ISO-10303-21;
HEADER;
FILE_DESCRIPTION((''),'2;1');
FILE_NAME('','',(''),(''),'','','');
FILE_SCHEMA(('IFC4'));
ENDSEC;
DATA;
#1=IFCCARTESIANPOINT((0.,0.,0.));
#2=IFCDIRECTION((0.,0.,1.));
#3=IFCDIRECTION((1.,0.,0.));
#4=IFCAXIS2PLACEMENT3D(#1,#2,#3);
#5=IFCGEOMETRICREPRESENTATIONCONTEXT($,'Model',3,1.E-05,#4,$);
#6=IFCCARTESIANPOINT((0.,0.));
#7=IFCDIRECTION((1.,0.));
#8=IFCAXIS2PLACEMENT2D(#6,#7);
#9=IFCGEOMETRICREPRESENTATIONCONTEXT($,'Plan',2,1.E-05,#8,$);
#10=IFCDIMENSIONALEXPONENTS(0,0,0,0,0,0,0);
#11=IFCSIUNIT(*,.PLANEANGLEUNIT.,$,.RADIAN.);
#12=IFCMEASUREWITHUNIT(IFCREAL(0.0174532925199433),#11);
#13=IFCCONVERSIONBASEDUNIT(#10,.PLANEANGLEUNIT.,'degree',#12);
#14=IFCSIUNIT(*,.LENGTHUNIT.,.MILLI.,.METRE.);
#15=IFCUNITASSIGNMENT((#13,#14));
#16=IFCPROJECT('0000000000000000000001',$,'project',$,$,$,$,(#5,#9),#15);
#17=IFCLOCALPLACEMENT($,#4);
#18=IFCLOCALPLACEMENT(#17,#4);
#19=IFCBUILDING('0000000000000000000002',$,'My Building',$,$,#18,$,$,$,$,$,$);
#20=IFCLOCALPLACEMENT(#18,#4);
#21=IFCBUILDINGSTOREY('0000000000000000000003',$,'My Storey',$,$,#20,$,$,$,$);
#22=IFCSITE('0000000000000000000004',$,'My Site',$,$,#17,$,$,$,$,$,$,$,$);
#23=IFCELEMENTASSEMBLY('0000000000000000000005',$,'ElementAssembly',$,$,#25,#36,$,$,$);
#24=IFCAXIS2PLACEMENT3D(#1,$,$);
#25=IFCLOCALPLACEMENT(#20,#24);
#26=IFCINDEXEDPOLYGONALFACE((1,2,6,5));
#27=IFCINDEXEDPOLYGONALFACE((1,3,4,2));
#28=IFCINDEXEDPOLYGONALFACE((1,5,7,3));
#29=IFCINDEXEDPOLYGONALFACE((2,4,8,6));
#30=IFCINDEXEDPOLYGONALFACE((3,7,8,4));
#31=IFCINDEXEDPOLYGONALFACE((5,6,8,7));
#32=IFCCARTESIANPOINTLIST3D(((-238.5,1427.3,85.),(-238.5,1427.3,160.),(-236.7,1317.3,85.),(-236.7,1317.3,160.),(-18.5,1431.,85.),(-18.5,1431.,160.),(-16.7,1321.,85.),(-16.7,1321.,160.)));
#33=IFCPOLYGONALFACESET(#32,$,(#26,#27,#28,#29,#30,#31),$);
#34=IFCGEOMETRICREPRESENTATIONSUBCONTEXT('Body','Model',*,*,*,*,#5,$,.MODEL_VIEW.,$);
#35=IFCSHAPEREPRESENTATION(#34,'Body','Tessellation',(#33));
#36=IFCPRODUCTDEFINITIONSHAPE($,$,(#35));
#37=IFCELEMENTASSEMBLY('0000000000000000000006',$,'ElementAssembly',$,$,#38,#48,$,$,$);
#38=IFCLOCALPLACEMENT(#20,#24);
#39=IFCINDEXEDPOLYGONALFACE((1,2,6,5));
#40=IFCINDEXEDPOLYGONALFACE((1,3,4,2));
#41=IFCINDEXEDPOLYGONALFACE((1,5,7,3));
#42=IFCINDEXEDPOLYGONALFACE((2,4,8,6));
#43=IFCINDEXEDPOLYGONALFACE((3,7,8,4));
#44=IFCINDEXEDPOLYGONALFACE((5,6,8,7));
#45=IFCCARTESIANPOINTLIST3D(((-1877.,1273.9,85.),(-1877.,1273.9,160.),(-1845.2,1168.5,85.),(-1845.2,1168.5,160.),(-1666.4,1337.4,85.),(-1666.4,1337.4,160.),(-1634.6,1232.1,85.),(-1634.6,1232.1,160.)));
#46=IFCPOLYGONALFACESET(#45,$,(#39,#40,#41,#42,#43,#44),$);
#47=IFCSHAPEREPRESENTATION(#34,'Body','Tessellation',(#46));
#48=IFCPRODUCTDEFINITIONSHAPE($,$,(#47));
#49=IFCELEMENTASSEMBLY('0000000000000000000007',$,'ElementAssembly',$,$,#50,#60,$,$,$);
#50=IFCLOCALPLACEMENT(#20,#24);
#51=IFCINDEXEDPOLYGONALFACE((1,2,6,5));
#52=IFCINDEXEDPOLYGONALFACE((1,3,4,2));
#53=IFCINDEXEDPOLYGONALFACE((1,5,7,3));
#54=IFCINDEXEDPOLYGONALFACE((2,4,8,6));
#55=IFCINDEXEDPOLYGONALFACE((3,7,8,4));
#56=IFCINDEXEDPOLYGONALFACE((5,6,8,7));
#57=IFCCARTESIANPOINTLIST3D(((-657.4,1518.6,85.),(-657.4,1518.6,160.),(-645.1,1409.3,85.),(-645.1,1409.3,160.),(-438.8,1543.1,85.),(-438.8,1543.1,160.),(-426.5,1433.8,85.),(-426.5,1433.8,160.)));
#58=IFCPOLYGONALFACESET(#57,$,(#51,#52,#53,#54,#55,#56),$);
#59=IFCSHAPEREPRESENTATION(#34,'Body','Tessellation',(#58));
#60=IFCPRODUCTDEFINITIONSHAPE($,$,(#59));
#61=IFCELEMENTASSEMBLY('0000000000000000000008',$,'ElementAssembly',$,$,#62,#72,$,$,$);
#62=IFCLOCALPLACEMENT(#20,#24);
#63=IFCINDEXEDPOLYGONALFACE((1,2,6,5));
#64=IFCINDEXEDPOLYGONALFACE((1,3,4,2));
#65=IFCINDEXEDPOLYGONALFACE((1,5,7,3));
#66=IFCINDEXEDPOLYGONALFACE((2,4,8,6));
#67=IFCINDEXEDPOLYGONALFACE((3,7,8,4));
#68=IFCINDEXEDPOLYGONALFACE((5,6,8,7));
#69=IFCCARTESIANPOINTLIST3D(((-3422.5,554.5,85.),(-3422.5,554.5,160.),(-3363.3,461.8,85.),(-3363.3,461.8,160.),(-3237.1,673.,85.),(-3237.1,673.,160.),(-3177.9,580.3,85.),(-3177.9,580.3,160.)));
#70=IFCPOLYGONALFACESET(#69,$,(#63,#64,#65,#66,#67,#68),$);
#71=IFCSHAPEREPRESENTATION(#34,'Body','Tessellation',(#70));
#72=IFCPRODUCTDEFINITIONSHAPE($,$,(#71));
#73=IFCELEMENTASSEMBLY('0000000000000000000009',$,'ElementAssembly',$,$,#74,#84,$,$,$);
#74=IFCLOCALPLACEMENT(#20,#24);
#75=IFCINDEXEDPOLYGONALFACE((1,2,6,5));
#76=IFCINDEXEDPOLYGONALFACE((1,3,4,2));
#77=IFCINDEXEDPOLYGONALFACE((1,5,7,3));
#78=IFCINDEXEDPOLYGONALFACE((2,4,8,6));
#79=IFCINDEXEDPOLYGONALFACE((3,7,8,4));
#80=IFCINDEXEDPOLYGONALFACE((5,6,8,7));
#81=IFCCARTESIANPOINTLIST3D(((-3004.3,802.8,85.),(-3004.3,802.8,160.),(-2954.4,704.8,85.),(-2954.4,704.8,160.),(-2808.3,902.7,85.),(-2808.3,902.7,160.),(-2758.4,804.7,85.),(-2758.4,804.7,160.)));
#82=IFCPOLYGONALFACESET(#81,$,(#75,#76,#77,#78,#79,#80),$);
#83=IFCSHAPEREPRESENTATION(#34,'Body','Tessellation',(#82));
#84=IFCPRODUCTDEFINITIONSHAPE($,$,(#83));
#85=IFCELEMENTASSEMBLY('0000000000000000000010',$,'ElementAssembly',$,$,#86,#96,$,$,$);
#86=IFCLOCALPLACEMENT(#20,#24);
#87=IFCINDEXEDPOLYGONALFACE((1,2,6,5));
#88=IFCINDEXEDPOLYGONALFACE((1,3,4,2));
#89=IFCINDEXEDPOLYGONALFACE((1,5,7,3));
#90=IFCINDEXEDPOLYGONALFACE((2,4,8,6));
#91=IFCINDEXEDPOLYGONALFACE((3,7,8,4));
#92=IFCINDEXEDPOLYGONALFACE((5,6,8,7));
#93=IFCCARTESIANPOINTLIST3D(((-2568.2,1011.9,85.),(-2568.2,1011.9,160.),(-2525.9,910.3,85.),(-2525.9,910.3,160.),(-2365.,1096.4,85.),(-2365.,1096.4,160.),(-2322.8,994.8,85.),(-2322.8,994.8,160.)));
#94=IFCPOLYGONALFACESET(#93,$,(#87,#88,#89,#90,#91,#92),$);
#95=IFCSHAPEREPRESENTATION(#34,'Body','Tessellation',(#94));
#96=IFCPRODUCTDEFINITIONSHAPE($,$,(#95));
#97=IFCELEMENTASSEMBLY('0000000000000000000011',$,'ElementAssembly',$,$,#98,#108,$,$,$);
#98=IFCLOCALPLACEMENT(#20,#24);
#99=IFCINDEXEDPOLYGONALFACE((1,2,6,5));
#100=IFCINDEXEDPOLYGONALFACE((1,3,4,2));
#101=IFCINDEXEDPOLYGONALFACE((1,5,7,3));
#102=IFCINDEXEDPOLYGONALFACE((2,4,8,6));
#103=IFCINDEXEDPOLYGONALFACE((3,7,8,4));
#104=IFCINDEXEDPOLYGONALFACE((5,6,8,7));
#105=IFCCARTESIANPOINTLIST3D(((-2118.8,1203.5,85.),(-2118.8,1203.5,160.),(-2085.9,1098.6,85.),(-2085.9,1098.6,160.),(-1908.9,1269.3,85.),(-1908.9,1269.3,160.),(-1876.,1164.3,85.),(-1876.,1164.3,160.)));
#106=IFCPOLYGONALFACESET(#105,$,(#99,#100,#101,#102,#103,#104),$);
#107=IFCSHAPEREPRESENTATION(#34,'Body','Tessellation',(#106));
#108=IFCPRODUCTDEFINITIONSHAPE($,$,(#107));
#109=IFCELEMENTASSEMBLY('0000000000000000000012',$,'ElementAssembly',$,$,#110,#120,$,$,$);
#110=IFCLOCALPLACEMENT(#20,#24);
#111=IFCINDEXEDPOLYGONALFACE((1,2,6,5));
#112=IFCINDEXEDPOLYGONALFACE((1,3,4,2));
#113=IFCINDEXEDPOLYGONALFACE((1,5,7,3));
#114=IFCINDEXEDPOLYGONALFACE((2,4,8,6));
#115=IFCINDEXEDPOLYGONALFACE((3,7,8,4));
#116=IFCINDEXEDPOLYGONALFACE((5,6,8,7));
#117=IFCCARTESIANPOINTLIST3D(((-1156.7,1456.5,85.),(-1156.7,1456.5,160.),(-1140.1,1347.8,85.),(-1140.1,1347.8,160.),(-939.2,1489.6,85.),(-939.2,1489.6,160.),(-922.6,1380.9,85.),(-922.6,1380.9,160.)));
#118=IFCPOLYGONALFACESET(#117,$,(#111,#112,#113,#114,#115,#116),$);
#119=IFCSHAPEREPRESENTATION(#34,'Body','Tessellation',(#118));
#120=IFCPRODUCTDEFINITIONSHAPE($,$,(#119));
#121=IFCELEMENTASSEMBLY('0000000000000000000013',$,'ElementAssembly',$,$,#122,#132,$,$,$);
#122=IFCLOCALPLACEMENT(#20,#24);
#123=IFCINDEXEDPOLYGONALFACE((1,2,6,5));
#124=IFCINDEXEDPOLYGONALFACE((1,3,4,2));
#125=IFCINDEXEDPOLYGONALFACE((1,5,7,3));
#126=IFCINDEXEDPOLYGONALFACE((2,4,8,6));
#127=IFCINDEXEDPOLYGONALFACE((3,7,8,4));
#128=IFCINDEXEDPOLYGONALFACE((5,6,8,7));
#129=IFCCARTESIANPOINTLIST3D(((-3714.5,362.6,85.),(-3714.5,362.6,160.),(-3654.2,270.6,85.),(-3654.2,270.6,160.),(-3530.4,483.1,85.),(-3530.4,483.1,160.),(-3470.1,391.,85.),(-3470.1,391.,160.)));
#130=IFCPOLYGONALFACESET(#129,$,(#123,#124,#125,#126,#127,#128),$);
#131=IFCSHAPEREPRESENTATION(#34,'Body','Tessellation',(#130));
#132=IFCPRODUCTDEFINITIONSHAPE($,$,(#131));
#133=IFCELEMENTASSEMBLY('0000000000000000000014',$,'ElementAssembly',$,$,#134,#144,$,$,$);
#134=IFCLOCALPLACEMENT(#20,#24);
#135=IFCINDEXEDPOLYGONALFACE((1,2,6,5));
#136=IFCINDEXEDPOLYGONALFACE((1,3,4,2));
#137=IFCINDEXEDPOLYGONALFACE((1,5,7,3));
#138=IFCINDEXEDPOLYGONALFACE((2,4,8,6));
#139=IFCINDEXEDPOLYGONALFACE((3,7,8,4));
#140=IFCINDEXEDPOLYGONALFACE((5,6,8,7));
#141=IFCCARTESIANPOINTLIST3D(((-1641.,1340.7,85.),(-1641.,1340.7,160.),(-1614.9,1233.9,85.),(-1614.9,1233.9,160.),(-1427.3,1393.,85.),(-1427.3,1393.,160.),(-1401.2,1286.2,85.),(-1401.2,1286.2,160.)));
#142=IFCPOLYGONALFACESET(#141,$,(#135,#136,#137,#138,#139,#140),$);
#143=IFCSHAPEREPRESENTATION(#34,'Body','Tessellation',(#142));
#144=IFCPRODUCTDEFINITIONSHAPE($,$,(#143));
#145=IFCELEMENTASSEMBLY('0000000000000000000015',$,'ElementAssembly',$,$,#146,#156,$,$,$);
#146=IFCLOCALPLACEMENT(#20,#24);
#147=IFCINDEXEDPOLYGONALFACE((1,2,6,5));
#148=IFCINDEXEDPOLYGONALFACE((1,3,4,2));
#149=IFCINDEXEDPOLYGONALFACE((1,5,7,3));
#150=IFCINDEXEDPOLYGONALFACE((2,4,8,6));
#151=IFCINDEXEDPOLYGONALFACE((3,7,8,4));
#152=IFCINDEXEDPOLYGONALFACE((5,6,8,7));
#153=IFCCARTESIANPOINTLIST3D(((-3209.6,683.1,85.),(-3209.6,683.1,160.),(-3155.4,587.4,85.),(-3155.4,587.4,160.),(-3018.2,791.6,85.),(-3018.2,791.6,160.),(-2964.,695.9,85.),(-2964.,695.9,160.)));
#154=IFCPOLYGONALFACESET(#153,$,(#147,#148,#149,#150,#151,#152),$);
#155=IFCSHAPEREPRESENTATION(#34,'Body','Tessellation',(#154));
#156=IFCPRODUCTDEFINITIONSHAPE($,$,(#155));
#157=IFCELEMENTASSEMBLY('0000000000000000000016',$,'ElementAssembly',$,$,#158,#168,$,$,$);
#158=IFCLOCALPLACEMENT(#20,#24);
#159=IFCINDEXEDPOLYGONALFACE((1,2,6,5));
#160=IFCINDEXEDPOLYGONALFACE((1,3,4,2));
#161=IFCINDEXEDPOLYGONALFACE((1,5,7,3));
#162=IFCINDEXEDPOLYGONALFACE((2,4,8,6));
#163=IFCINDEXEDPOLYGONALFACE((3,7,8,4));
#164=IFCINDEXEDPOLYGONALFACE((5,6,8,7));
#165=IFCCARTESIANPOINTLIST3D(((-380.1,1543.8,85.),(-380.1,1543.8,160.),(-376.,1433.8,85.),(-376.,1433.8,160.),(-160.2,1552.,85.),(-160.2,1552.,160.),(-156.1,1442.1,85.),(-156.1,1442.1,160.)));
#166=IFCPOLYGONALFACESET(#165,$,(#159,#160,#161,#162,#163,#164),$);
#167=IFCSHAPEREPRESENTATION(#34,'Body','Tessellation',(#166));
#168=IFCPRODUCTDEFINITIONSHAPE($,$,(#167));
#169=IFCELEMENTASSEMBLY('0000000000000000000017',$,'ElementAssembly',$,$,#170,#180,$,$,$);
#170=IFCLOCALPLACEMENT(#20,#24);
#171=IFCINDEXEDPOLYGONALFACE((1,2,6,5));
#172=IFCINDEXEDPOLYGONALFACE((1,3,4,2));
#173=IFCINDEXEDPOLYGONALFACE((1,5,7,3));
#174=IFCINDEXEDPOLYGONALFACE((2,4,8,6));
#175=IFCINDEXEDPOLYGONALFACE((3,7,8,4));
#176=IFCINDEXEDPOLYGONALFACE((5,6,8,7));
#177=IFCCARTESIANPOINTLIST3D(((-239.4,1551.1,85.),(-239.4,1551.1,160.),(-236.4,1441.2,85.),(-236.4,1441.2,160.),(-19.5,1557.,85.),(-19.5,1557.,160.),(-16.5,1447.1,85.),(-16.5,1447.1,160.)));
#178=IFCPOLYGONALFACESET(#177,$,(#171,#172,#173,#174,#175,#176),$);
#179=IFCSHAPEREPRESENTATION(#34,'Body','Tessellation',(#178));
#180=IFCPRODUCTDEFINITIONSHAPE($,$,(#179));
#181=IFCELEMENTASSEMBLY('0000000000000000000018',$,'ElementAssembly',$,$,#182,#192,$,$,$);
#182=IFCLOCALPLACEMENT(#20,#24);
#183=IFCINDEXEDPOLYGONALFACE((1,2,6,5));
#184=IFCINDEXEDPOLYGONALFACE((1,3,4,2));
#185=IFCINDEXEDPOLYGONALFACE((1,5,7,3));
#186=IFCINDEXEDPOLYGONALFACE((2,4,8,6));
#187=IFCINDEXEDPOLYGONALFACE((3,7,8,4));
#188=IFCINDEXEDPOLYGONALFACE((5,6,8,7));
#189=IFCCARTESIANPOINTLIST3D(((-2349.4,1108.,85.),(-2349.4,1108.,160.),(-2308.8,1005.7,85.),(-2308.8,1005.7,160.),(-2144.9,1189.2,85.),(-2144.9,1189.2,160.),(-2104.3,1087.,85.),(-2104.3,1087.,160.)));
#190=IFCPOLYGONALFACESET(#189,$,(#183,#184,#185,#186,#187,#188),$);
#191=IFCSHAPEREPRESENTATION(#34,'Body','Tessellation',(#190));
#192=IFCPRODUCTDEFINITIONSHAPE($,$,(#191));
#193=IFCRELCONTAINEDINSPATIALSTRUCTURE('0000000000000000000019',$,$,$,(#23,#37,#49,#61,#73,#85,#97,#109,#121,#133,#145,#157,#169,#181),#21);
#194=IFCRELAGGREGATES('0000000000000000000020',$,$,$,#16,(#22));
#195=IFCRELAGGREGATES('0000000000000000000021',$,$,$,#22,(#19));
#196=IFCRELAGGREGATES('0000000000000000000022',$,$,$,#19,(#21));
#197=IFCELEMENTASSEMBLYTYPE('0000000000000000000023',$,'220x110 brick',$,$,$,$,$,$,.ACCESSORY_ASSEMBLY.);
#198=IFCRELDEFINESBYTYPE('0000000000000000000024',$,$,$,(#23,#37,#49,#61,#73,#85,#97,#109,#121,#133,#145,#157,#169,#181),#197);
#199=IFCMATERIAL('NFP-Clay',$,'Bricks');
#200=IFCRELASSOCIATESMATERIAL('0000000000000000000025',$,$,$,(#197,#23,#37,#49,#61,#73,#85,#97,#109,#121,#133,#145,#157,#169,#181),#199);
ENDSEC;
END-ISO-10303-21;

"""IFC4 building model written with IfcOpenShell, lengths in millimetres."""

from ifc_helpers import new_model, entity, si_unit, converted_unit, frame, origin_with_axes, origin_2d_with_axis, place, context, subcontext, project, spatial, rectangle, extrude, material, material_profile, profile_set, profile_usage, type_object, element, save


model = new_model("IFC4")

# Units and contexts
model_context = context("Model", 3, precision=1e-05, world=origin_with_axes())
plan_context = context("Plan", 2, precision=1e-05, world=origin_2d_with_axis())
body_context = subcontext(model_context, "Body", "Model", "MODEL_VIEW")
ifc_project = project(units=[converted_unit("PLANEANGLEUNIT", "degree", entity("IfcReal", 0.0174532925199433), si_unit("PLANEANGLEUNIT", "RADIAN"), dimensions=[0, 0, 0, 0, 0, 0, 0]), si_unit("LENGTHUNIT", "METRE", prefix="MILLI")], contexts=[model_context, plan_context])

# Site, building, storey
site_placement = place(None, origin_with_axes())
site = spatial("IfcSite", under=ifc_project, at=site_placement, Name="My Site")
building_placement = place(site_placement, origin_with_axes())
building = spatial("IfcBuilding", under=site, at=building_placement, Name="My Building")
storey_placement = place(building_placement, origin_with_axes())
storey = spatial("IfcBuildingStorey", under=building, at=storey_placement, Name="My Storey")

# Element assemblies
ifc_material = material(Name="NFP-Clay", Category="Bricks")
ifc_material_profile = material_profile(ifc_material, rectangle(XDim=220.0, YDim=110.0))
ifc_profile_set = profile_set([ifc_material_profile])
element_assembly_type = type_object("IfcElementAssemblyType", Name="220x110 brick", PredefinedType="ACCESSORY_ASSEMBLY", material=ifc_profile_set)
ifc_profile_usage_1 = profile_usage(ifc_profile_set, cardinal=5)
assembly_1_placement = place(storey_placement, frame((-127.6, 1374.2, 85.0), z_axis=(0.0, 0.0, 1.0), x_axis=(0.999857, 0.016917, 0.0)))
element("IfcElementAssembly", 1, at=assembly_1_placement, inside=storey, type_object=element_assembly_type, material=ifc_profile_usage_1, Name="ElementAssembly", context=body_context, shape_type="SweptSolid", body=[
    extrude(rectangle(XDim=220.0, YDim=110.0), origin_with_axes(), (0.0, 0.0, 1.0), 75.0),
])
ifc_profile_usage_2 = profile_usage(ifc_profile_set, cardinal=5)
assembly_2_placement = place(storey_placement, frame((-1755.8, 1253.0, 85.0), z_axis=(0.0, 0.0, 1.0), x_axis=(0.957384, 0.288817, 0.0)))
element("IfcElementAssembly", 2, at=assembly_2_placement, inside=storey, type_object=element_assembly_type, material=ifc_profile_usage_2, Name="ElementAssembly", context=body_context, shape_type="SweptSolid", body=[
    extrude(rectangle(XDim=220.0, YDim=110.0), origin_with_axes(), (0.0, 0.0, 1.0), 75.0),
])
ifc_profile_usage_3 = profile_usage(ifc_profile_set, cardinal=5)
assembly_3_placement = place(storey_placement, frame((-542.0, 1476.2, 85.0), z_axis=(0.0, 0.0, 1.0), x_axis=(0.993747, 0.111655, 0.0)))
element("IfcElementAssembly", 3, at=assembly_3_placement, inside=storey, type_object=element_assembly_type, material=ifc_profile_usage_3, Name="ElementAssembly", context=body_context, shape_type="SweptSolid", body=[
    extrude(rectangle(XDim=220.0, YDim=110.0), origin_with_axes(), (0.0, 0.0, 1.0), 75.0),
])
ifc_profile_usage_4 = profile_usage(ifc_profile_set, cardinal=5)
assembly_4_placement = place(storey_placement, frame((-3300.2, 567.4, 85.0), z_axis=(0.0, 0.0, 1.0), x_axis=(0.842597, 0.538544, 0.0)))
element("IfcElementAssembly", 4, at=assembly_4_placement, inside=storey, type_object=element_assembly_type, material=ifc_profile_usage_4, Name="ElementAssembly", context=body_context, shape_type="SweptSolid", body=[
    extrude(rectangle(XDim=220.0, YDim=110.0), origin_with_axes(), (0.0, 0.0, 1.0), 75.0),
])
ifc_profile_usage_5 = profile_usage(ifc_profile_set, cardinal=5)
assembly_5_placement = place(storey_placement, frame((-2881.3, 803.8, 85.0), z_axis=(0.0, 0.0, 1.0), x_axis=(0.890943, 0.454115, 0.0)))
element("IfcElementAssembly", 5, at=assembly_5_placement, inside=storey, type_object=element_assembly_type, material=ifc_profile_usage_5, Name="ElementAssembly", context=body_context, shape_type="SweptSolid", body=[
    extrude(rectangle(XDim=220.0, YDim=110.0), origin_with_axes(), (0.0, 0.0, 1.0), 75.0),
])
ifc_profile_usage_6 = profile_usage(ifc_profile_set, cardinal=5)
assembly_6_placement = place(storey_placement, frame((-2445.5, 1003.3, 85.0), z_axis=(0.0, 0.0, 1.0), x_axis=(0.923349, 0.383961, 0.0)))
element("IfcElementAssembly", 6, at=assembly_6_placement, inside=storey, type_object=element_assembly_type, material=ifc_profile_usage_6, Name="ElementAssembly", context=body_context, shape_type="SweptSolid", body=[
    extrude(rectangle(XDim=220.0, YDim=110.0), origin_with_axes(), (0.0, 0.0, 1.0), 75.0),
])
ifc_profile_usage_7 = profile_usage(ifc_profile_set, cardinal=5)
assembly_7_placement = place(storey_placement, frame((-1997.4, 1183.9, 85.0), z_axis=(0.0, 0.0, 1.0), x_axis=(0.954249, 0.299013, 0.0)))
element("IfcElementAssembly", 7, at=assembly_7_placement, inside=storey, type_object=element_assembly_type, material=ifc_profile_usage_7, Name="ElementAssembly", context=body_context, shape_type="SweptSolid", body=[
    extrude(rectangle(XDim=220.0, YDim=110.0), origin_with_axes(), (0.0, 0.0, 1.0), 75.0),
])
ifc_profile_usage_8 = profile_usage(ifc_profile_set, cardinal=5)
assembly_8_placement = place(storey_placement, frame((-1039.7, 1418.7, 85.0), z_axis=(0.0, 0.0, 1.0), x_axis=(0.98862, 0.150436, 0.0)))
element("IfcElementAssembly", 8, at=assembly_8_placement, inside=storey, type_object=element_assembly_type, material=ifc_profile_usage_8, Name="ElementAssembly", context=body_context, shape_type="SweptSolid", body=[
    extrude(rectangle(XDim=220.0, YDim=110.0), origin_with_axes(), (0.0, 0.0, 1.0), 75.0),
])
ifc_profile_usage_9 = profile_usage(ifc_profile_set, cardinal=5)
assembly_9_placement = place(storey_placement, frame((-3592.3, 376.8, 85.0), z_axis=(0.0, 0.0, 1.0), x_axis=(0.836805, 0.547502, 0.0)))
element("IfcElementAssembly", 9, at=assembly_9_placement, inside=storey, type_object=element_assembly_type, material=ifc_profile_usage_9, Name="ElementAssembly", context=body_context, shape_type="SweptSolid", body=[
    extrude(rectangle(XDim=220.0, YDim=110.0), origin_with_axes(), (0.0, 0.0, 1.0), 75.0),
])
ifc_profile_usage_10 = profile_usage(ifc_profile_set, cardinal=5)
assembly_10_placement = place(storey_placement, frame((-1521.1, 1313.4, 85.0), z_axis=(0.0, 0.0, 1.0), x_axis=(0.971317, 0.237789, 0.0)))
element("IfcElementAssembly", 10, at=assembly_10_placement, inside=storey, type_object=element_assembly_type, material=ifc_profile_usage_10, Name="ElementAssembly", context=body_context, shape_type="SweptSolid", body=[
    extrude(rectangle(XDim=220.0, YDim=110.0), origin_with_axes(), (0.0, 0.0, 1.0), 75.0),
])
ifc_profile_usage_11 = profile_usage(ifc_profile_set, cardinal=5)
assembly_11_placement = place(storey_placement, frame((-3086.8, 689.5, 85.0), z_axis=(0.0, 0.0, 1.0), x_axis=(0.869896, 0.493236, 0.0)))
element("IfcElementAssembly", 11, at=assembly_11_placement, inside=storey, type_object=element_assembly_type, material=ifc_profile_usage_11, Name="ElementAssembly", context=body_context, shape_type="SweptSolid", body=[
    extrude(rectangle(XDim=220.0, YDim=110.0), origin_with_axes(), (0.0, 0.0, 1.0), 75.0),
])
ifc_profile_usage_12 = profile_usage(ifc_profile_set, cardinal=5)
assembly_12_placement = place(storey_placement, frame((-268.1, 1492.9, 85.0), z_axis=(0.0, 0.0, 1.0), x_axis=(0.999298, 0.037458, 0.0)))
element("IfcElementAssembly", 12, at=assembly_12_placement, inside=storey, type_object=element_assembly_type, material=ifc_profile_usage_12, Name="ElementAssembly", context=body_context, shape_type="SweptSolid", body=[
    extrude(rectangle(XDim=220.0, YDim=110.0), origin_with_axes(), (0.0, 0.0, 1.0), 75.0),
])
ifc_profile_usage_13 = profile_usage(ifc_profile_set, cardinal=5)
assembly_13_placement = place(storey_placement, frame((-128.0, 1499.1, 85.0), z_axis=(0.0, 0.0, 1.0), x_axis=(0.999641, 0.026797, 0.0)))
element("IfcElementAssembly", 13, at=assembly_13_placement, inside=storey, type_object=element_assembly_type, material=ifc_profile_usage_13, Name="ElementAssembly", context=body_context, shape_type="SweptSolid", body=[
    extrude(rectangle(XDim=220.0, YDim=110.0), origin_with_axes(), (0.0, 0.0, 1.0), 75.0),
])
ifc_profile_usage_14 = profile_usage(ifc_profile_set, cardinal=5)
assembly_14_placement = place(storey_placement, frame((-2226.8, 1097.5, 85.0), z_axis=(0.0, 0.0, 1.0), x_axis=(0.929375, 0.369137, 0.0)))
element("IfcElementAssembly", 14, at=assembly_14_placement, inside=storey, type_object=element_assembly_type, material=ifc_profile_usage_14, Name="ElementAssembly", context=body_context, shape_type="SweptSolid", body=[
    extrude(rectangle(XDim=220.0, YDim=110.0), origin_with_axes(), (0.0, 0.0, 1.0), 75.0),
])

save(model, "model.ifc")
